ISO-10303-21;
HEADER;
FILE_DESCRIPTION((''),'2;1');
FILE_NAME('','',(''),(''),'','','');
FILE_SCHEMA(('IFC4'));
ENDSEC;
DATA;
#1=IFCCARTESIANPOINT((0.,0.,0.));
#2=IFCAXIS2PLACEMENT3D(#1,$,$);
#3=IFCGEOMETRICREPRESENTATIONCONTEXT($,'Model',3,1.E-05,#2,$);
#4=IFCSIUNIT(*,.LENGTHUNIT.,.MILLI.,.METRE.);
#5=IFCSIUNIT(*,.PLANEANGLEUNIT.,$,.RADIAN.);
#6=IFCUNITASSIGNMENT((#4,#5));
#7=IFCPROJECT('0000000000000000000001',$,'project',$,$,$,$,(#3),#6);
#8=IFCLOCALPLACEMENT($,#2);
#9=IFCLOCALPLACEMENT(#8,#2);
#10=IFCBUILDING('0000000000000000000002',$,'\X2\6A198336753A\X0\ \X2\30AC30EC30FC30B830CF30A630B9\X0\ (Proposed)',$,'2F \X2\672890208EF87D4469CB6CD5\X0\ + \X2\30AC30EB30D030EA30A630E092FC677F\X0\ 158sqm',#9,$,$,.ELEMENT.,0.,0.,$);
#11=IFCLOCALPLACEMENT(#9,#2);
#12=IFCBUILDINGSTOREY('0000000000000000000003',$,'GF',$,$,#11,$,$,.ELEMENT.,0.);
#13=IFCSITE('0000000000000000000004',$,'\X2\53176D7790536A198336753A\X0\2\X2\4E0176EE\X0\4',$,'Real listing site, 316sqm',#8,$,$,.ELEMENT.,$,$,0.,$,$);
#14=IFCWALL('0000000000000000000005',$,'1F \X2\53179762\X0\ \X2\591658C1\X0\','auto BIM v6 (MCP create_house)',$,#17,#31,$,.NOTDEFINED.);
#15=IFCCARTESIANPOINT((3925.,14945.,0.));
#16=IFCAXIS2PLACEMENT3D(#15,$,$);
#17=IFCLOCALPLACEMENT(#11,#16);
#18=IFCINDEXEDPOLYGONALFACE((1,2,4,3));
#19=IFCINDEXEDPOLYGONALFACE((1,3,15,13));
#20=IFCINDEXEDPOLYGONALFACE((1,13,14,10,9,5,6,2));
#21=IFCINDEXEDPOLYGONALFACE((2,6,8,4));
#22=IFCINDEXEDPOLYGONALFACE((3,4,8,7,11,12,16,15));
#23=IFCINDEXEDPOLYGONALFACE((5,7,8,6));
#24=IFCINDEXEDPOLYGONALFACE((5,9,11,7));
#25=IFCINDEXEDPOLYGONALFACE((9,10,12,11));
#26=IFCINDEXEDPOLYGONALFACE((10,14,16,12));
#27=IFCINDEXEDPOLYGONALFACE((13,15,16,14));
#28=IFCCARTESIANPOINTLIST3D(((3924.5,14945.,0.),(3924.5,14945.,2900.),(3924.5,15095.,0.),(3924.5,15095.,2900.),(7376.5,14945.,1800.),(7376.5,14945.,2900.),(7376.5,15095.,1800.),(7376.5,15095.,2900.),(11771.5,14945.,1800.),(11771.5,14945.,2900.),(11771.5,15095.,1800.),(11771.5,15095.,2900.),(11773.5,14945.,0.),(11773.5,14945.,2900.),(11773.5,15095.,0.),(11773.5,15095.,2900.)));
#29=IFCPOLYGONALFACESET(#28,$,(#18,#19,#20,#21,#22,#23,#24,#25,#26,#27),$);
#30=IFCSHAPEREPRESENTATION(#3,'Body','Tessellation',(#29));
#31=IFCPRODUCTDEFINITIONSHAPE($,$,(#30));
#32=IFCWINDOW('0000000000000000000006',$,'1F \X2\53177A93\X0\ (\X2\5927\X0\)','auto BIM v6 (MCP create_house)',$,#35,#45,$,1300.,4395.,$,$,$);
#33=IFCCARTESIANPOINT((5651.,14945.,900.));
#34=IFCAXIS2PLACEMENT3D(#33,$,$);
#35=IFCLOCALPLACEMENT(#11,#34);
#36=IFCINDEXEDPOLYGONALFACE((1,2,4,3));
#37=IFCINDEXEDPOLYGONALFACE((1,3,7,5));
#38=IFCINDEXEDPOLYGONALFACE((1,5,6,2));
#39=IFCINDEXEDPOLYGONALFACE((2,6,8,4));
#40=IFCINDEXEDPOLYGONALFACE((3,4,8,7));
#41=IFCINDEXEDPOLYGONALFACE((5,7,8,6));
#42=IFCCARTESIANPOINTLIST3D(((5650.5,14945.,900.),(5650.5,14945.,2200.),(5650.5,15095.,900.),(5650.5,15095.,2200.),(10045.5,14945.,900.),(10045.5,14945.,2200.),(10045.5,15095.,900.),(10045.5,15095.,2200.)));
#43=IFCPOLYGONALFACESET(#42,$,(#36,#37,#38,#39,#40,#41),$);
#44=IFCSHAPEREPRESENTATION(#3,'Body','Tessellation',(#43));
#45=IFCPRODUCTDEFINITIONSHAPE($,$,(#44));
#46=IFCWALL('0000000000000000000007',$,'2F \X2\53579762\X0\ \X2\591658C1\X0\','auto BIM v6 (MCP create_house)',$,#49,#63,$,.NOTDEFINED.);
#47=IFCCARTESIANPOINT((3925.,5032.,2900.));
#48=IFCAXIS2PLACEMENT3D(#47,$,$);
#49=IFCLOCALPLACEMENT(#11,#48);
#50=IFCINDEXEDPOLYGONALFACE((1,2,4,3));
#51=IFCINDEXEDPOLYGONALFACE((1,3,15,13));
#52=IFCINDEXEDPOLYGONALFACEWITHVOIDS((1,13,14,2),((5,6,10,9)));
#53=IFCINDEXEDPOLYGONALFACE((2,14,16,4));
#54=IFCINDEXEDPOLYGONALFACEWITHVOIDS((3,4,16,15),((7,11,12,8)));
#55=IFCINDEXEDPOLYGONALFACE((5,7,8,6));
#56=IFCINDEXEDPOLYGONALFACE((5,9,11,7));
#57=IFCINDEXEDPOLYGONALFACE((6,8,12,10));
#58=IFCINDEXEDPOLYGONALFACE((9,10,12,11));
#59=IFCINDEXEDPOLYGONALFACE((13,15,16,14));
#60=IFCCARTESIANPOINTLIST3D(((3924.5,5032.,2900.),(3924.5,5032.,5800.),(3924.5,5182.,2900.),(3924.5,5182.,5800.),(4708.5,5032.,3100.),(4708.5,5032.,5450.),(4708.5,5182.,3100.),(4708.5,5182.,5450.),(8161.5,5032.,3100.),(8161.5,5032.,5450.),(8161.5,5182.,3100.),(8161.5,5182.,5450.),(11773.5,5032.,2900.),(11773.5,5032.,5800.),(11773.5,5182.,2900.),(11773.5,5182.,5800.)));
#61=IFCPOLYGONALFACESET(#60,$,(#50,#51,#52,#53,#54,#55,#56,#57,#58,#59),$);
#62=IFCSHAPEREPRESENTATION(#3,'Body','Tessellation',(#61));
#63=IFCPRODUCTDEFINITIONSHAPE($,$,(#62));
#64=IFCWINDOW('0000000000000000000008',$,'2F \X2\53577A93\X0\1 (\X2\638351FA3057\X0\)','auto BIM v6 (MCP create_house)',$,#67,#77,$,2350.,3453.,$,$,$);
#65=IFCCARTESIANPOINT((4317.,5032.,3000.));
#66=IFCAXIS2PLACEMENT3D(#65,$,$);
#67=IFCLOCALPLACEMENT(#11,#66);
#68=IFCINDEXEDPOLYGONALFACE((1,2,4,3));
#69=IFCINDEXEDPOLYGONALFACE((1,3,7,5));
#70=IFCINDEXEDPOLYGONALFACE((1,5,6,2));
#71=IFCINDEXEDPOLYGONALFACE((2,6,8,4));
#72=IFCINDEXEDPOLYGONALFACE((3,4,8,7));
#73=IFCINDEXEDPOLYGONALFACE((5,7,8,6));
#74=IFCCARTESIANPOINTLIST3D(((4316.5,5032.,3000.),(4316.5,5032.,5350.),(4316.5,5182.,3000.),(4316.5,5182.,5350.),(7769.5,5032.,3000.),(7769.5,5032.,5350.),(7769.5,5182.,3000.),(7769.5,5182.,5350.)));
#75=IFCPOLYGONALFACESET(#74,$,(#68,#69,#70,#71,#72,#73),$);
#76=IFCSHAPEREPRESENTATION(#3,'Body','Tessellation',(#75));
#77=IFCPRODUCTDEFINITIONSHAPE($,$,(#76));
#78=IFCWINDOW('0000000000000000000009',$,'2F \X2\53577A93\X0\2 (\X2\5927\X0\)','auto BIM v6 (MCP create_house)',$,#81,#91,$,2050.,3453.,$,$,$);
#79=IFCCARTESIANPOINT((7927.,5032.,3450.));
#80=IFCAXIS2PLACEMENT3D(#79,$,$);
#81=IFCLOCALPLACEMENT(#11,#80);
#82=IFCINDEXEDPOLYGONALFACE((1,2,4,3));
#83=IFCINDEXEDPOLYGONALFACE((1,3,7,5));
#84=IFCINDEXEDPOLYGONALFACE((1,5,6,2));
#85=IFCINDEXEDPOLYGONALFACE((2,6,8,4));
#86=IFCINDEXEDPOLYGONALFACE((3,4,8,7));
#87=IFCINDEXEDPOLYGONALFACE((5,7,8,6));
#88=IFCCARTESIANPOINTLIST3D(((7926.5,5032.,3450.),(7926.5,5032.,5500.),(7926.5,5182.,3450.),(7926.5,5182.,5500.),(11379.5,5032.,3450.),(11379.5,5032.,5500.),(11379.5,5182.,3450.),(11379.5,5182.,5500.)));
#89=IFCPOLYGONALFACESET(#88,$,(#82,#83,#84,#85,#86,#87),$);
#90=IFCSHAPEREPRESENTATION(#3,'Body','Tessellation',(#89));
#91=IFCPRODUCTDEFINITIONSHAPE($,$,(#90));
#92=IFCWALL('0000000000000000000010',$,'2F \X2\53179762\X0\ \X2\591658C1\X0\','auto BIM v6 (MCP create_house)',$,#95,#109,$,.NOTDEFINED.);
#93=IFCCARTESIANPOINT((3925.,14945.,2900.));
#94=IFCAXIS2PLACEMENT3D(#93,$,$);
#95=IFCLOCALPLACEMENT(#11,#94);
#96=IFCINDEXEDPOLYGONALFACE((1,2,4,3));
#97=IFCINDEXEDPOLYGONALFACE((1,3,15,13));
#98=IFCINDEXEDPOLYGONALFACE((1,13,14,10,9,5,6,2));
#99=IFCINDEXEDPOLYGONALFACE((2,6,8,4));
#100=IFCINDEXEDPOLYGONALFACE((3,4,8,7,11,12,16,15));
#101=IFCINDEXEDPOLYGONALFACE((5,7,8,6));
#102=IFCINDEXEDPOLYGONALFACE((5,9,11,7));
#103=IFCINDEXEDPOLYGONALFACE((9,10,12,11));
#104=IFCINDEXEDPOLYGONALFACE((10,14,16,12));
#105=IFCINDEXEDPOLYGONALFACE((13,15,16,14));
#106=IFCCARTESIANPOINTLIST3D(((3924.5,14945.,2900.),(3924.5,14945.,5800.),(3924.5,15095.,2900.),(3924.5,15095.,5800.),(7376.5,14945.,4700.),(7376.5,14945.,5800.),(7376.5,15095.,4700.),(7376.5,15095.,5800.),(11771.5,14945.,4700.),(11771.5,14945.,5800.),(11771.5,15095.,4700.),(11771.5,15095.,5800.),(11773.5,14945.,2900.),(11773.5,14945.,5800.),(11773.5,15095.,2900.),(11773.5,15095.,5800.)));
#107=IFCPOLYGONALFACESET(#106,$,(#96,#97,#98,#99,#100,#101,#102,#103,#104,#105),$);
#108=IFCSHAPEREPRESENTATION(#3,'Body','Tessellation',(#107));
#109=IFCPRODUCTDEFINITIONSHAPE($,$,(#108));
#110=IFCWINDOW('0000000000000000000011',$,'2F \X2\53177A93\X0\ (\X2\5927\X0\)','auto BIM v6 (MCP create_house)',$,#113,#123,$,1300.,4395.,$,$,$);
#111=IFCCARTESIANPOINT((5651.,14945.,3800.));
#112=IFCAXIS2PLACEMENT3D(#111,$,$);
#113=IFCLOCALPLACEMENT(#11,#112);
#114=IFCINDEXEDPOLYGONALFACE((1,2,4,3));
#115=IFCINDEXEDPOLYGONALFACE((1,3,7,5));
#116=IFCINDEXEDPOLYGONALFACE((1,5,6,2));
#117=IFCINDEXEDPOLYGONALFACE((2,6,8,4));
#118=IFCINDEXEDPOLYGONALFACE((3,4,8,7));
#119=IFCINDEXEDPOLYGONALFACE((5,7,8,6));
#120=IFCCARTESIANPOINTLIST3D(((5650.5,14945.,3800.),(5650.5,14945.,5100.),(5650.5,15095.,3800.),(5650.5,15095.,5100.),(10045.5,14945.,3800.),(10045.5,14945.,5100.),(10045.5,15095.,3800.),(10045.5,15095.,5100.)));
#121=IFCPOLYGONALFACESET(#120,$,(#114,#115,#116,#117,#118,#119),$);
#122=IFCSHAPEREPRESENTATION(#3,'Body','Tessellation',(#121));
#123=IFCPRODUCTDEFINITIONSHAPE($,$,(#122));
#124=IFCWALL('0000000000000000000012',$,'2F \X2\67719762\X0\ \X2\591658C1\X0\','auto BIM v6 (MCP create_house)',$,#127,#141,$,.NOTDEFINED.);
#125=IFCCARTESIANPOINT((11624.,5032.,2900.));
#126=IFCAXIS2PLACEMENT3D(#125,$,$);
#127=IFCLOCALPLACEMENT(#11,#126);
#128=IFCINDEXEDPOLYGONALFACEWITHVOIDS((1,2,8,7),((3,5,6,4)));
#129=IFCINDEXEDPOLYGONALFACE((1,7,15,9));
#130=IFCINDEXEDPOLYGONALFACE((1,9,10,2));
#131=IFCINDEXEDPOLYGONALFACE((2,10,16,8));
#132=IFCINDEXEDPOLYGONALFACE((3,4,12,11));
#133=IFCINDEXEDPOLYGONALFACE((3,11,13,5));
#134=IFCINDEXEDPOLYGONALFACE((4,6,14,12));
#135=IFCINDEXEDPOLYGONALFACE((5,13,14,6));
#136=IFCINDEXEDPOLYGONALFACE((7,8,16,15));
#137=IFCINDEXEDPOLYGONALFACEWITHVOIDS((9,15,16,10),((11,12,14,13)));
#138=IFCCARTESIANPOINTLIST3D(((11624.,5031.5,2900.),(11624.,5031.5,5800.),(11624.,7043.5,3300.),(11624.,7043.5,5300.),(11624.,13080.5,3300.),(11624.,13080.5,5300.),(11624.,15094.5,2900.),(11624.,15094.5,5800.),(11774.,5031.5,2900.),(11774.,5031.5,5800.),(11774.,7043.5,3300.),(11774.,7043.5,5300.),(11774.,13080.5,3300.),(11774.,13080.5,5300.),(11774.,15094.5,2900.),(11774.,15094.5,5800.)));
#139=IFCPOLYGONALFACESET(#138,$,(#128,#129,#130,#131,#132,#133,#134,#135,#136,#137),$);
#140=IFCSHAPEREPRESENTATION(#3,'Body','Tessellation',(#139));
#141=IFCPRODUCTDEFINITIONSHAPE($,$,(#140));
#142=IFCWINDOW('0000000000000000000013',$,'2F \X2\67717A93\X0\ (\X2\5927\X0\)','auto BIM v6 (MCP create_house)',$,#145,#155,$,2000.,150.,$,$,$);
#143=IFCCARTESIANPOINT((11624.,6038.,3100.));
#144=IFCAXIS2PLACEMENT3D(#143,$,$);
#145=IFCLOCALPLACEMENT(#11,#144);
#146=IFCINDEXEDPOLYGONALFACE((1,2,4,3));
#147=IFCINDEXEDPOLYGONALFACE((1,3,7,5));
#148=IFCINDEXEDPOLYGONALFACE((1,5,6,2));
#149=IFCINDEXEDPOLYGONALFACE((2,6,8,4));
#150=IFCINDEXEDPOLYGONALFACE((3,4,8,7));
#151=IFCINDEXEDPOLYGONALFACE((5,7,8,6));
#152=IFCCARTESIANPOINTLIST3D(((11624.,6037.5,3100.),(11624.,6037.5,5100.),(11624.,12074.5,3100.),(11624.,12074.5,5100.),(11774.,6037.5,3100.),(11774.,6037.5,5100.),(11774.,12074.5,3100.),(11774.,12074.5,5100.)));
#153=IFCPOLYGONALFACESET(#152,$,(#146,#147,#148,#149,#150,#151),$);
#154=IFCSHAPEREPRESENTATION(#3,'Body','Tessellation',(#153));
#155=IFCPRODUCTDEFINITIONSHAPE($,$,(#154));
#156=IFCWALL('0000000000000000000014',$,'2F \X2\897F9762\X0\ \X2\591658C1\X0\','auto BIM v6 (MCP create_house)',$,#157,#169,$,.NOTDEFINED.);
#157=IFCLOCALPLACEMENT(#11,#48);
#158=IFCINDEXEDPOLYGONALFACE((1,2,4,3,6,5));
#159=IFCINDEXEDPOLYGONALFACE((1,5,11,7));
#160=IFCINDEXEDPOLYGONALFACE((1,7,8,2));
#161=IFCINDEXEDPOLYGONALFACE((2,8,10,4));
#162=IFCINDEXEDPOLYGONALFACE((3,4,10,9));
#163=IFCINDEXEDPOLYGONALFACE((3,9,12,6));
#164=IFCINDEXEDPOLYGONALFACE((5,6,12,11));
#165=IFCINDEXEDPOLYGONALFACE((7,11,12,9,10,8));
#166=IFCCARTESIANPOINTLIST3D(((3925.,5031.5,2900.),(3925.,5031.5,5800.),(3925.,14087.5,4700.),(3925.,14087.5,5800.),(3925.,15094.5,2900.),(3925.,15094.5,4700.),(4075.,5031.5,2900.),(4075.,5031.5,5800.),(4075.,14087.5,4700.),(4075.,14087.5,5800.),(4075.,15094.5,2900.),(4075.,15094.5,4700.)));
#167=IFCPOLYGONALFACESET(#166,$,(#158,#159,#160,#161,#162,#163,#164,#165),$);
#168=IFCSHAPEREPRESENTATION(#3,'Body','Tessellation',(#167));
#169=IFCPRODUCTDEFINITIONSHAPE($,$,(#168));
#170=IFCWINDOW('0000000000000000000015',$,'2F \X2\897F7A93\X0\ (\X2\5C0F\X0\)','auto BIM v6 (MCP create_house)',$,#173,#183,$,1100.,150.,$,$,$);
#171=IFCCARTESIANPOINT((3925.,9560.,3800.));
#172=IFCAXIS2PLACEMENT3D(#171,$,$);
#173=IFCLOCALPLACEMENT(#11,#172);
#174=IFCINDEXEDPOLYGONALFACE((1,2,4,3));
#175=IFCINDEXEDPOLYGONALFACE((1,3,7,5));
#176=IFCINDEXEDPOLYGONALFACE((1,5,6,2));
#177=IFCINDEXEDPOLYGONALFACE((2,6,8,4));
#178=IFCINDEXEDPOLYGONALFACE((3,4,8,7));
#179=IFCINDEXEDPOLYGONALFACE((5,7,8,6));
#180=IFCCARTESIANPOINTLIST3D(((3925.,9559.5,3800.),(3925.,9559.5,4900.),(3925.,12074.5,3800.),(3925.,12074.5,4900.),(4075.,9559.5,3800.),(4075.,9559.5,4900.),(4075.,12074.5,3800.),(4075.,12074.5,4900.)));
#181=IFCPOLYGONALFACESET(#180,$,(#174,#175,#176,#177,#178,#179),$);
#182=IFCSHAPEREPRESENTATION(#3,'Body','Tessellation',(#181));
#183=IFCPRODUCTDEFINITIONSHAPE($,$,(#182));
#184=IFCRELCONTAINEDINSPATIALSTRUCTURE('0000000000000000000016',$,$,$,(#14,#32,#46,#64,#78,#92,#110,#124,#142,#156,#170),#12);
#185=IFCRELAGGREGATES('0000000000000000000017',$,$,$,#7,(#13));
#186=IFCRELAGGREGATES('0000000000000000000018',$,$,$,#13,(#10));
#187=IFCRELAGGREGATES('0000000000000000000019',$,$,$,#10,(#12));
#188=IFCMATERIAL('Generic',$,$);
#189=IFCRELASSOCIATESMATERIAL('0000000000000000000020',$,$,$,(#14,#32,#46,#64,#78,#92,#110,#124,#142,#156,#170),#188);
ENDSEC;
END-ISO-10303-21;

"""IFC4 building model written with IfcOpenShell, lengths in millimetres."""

from ifc_helpers import new_model, si_unit, frame, frame_2d, origin, place, context, project, spatial, rectangle, extrude, material, element, fill, save


model = new_model("IFC4")

# Units and contexts
model_context = context("Model", 3, precision=1e-05, world=origin())
ifc_project = project(units=[si_unit("LENGTHUNIT", "METRE", prefix="MILLI"), si_unit("PLANEANGLEUNIT", "RADIAN")], contexts=[model_context])

# Site, building, storey
site_placement = place(None, origin())
site = spatial("IfcSite", under=ifc_project, at=site_placement, Name="北海道標茶町2丁目4", ObjectType="Real listing site, 316sqm", CompositionType="ELEMENT", RefElevation=0.0)
building_placement = place(site_placement, origin())
building = spatial("IfcBuilding", under=site, at=building_placement, Name="標茶町 ガレージハウス (Proposed)", ObjectType="2F 木造軸組構法 + ガルバリウム鋼板 158sqm", CompositionType="ELEMENT", ElevationOfRefHeight=0.0, ElevationOfTerrain=0.0)
storey_placement = place(building_placement, origin())
storey = spatial("IfcBuildingStorey", under=building, at=storey_placement, Name="GF", CompositionType="ELEMENT", Elevation=0.0)

# Wall, opening, window
ifc_material = material(Name="Generic")
wall_1_placement = place(storey_placement, frame((3925.0, 14945.0, 0.0)))
wall_1 = element("IfcWall", 1, at=wall_1_placement, inside=storey, material=ifc_material, Name="1F 北面 外壁", Description="auto BIM v6 (MCP create_house)", PredefinedType="NOTDEFINED", context=model_context, shape_type="SweptSolid", body=[
    extrude(rectangle(XDim=7849.0, YDim=150.0, at=frame_2d((3924.0, 75.0))), frame((3925.0, 14945.0, 0.0)), (0.0, 0.0, 1.0), 2900.0),
])
opening_1_placement = place(storey_placement, frame((5651.0, 14945.0, 900.0)))
opening_1 = element("IfcOpeningElement", 2, at=opening_1_placement, cuts=wall_1, PredefinedType="NOTDEFINED", context=model_context, shape_type="SweptSolid", body=[
    extrude(rectangle(XDim=4395.0, YDim=150.0, at=frame_2d((2197.0, 75.0))), frame((5651.0, 14945.0, 900.0)), (0.0, 0.0, 1.0), 1300.0),
])
window_1_placement = place(storey_placement, frame((5651.0, 14945.0, 900.0)))
window_1 = element("IfcWindow", 3, at=window_1_placement, inside=storey, material=ifc_material, Name="1F 北窓 (大)", Description="auto BIM v6 (MCP create_house)", OverallHeight=1300.0, OverallWidth=4395.0, context=model_context, shape_type="SweptSolid", body=[
    extrude(rectangle(XDim=4395.0, YDim=150.0, at=frame_2d((2197.0, 75.0))), frame((5651.0, 14945.0, 900.0)), (0.0, 0.0, 1.0), 1300.0),
])
fill(opening_1, window_1)

# Wall, openings, windows
wall_2_placement = place(storey_placement, frame((3925.0, 5032.0, 2900.0)))
wall_2 = element("IfcWall", 4, at=wall_2_placement, inside=storey, material=ifc_material, Name="2F 南面 外壁", Description="auto BIM v6 (MCP create_house)", PredefinedType="NOTDEFINED", context=model_context, shape_type="SweptSolid", body=[
    extrude(rectangle(XDim=7849.0, YDim=150.0, at=frame_2d((3924.0, 75.0))), frame((3925.0, 5032.0, 2900.0)), (0.0, 0.0, 1.0), 2900.0),
])
opening_2_placement = place(storey_placement, frame((4317.0, 5032.0, 3000.0)))
opening_2 = element("IfcOpeningElement", 5, at=opening_2_placement, cuts=wall_2, PredefinedType="NOTDEFINED", context=model_context, shape_type="SweptSolid", body=[
    extrude(rectangle(XDim=3453.0, YDim=150.0, at=frame_2d((1726.0, 75.0))), frame((4317.0, 5032.0, 3000.0)), (0.0, 0.0, 1.0), 2350.0),
])
opening_3_placement = place(storey_placement, frame((7927.0, 5032.0, 3450.0)))
opening_3 = element("IfcOpeningElement", 6, at=opening_3_placement, cuts=wall_2, PredefinedType="NOTDEFINED", context=model_context, shape_type="SweptSolid", body=[
    extrude(rectangle(XDim=3453.0, YDim=150.0, at=frame_2d((1726.0, 75.0))), frame((7927.0, 5032.0, 3450.0)), (0.0, 0.0, 1.0), 2050.0),
])
window_2_placement = place(storey_placement, frame((4317.0, 5032.0, 3000.0)))
window_2 = element("IfcWindow", 7, at=window_2_placement, inside=storey, material=ifc_material, Name="2F 南窓1 (掃出し)", Description="auto BIM v6 (MCP create_house)", OverallHeight=2350.0, OverallWidth=3453.0, context=model_context, shape_type="SweptSolid", body=[
    extrude(rectangle(XDim=3453.0, YDim=150.0, at=frame_2d((1726.0, 75.0))), frame((4317.0, 5032.0, 3000.0)), (0.0, 0.0, 1.0), 2350.0),
])
fill(opening_2, window_2)
window_3_placement = place(storey_placement, frame((7927.0, 5032.0, 3450.0)))
window_3 = element("IfcWindow", 8, at=window_3_placement, inside=storey, material=ifc_material, Name="2F 南窓2 (大)", Description="auto BIM v6 (MCP create_house)", OverallHeight=2050.0, OverallWidth=3453.0, context=model_context, shape_type="SweptSolid", body=[
    extrude(rectangle(XDim=3453.0, YDim=150.0, at=frame_2d((1726.0, 75.0))), frame((7927.0, 5032.0, 3450.0)), (0.0, 0.0, 1.0), 2050.0),
])
fill(opening_3, window_3)

# Walls, openings, windows
wall_3_placement = place(storey_placement, frame((3925.0, 14945.0, 2900.0)))
wall_3 = element("IfcWall", 9, at=wall_3_placement, inside=storey, material=ifc_material, Name="2F 北面 外壁", Description="auto BIM v6 (MCP create_house)", PredefinedType="NOTDEFINED", context=model_context, shape_type="SweptSolid", body=[
    extrude(rectangle(XDim=7849.0, YDim=150.0, at=frame_2d((3924.0, 75.0))), frame((3925.0, 14945.0, 2900.0)), (0.0, 0.0, 1.0), 2900.0),
])
opening_4_placement = place(storey_placement, frame((5651.0, 14945.0, 3800.0)))
opening_4 = element("IfcOpeningElement", 10, at=opening_4_placement, cuts=wall_3, PredefinedType="NOTDEFINED", context=model_context, shape_type="SweptSolid", body=[
    extrude(rectangle(XDim=4395.0, YDim=150.0, at=frame_2d((2197.0, 75.0))), frame((5651.0, 14945.0, 3800.0)), (0.0, 0.0, 1.0), 1300.0),
])
window_4_placement = place(storey_placement, frame((5651.0, 14945.0, 3800.0)))
window_4 = element("IfcWindow", 11, at=window_4_placement, inside=storey, material=ifc_material, Name="2F 北窓 (大)", Description="auto BIM v6 (MCP create_house)", OverallHeight=1300.0, OverallWidth=4395.0, context=model_context, shape_type="SweptSolid", body=[
    extrude(rectangle(XDim=4395.0, YDim=150.0, at=frame_2d((2197.0, 75.0))), frame((5651.0, 14945.0, 3800.0)), (0.0, 0.0, 1.0), 1300.0),
])
fill(opening_4, window_4)
wall_4_placement = place(storey_placement, frame((11624.0, 5032.0, 2900.0)))
wall_4 = element("IfcWall", 12, at=wall_4_placement, inside=storey, material=ifc_material, Name="2F 東面 外壁", Description="auto BIM v6 (MCP create_house)", PredefinedType="NOTDEFINED", context=model_context, shape_type="SweptSolid", body=[
    extrude(rectangle(XDim=150.0, YDim=10063.0, at=frame_2d((75.0, 5031.0))), frame((11624.0, 5032.0, 2900.0)), (0.0, 0.0, 1.0), 2900.0),
])
opening_5_placement = place(storey_placement, frame((11624.0, 6038.0, 3100.0)))
opening_5 = element("IfcOpeningElement", 13, at=opening_5_placement, cuts=wall_4, PredefinedType="NOTDEFINED", context=model_context, shape_type="SweptSolid", body=[
    extrude(rectangle(XDim=150.0, YDim=6037.0, at=frame_2d((75.0, 3018.0))), frame((11624.0, 6038.0, 3100.0)), (0.0, 0.0, 1.0), 2000.0),
])
window_5_placement = place(storey_placement, frame((11624.0, 6038.0, 3100.0)))
window_5 = element("IfcWindow", 14, at=window_5_placement, inside=storey, material=ifc_material, Name="2F 東窓 (大)", Description="auto BIM v6 (MCP create_house)", OverallHeight=2000.0, OverallWidth=150.0, context=model_context, shape_type="SweptSolid", body=[
    extrude(rectangle(XDim=150.0, YDim=6037.0, at=frame_2d((75.0, 3018.0))), frame((11624.0, 6038.0, 3100.0)), (0.0, 0.0, 1.0), 2000.0),
])
fill(opening_5, window_5)
wall_5_placement = place(storey_placement, frame((3925.0, 5032.0, 2900.0)))
wall_5 = element("IfcWall", 15, at=wall_5_placement, inside=storey, material=ifc_material, Name="2F 西面 外壁", Description="auto BIM v6 (MCP create_house)", PredefinedType="NOTDEFINED", context=model_context, shape_type="SweptSolid", body=[
    extrude(rectangle(XDim=150.0, YDim=10063.0, at=frame_2d((75.0, 5031.0))), frame((3925.0, 5032.0, 2900.0)), (0.0, 0.0, 1.0), 2900.0),
])
opening_6_placement = place(storey_placement, frame((3925.0, 9560.0, 3800.0)))
opening_6 = element("IfcOpeningElement", 16, at=opening_6_placement, cuts=wall_5, PredefinedType="NOTDEFINED", context=model_context, shape_type="SweptSolid", body=[
    extrude(rectangle(XDim=150.0, YDim=2515.0, at=frame_2d((75.0, 1257.0))), frame((3925.0, 9560.0, 3800.0)), (0.0, 0.0, 1.0), 1100.0),
])
window_6_placement = place(storey_placement, frame((3925.0, 9560.0, 3800.0)))
window_6 = element("IfcWindow", 17, at=window_6_placement, inside=storey, material=ifc_material, Name="2F 西窓 (小)", Description="auto BIM v6 (MCP create_house)", OverallHeight=1100.0, OverallWidth=150.0, context=model_context, shape_type="SweptSolid", body=[
    extrude(rectangle(XDim=150.0, YDim=2515.0, at=frame_2d((75.0, 1257.0))), frame((3925.0, 9560.0, 3800.0)), (0.0, 0.0, 1.0), 1100.0),
])
fill(opening_6, window_6)

save(model, "model.ifc")
